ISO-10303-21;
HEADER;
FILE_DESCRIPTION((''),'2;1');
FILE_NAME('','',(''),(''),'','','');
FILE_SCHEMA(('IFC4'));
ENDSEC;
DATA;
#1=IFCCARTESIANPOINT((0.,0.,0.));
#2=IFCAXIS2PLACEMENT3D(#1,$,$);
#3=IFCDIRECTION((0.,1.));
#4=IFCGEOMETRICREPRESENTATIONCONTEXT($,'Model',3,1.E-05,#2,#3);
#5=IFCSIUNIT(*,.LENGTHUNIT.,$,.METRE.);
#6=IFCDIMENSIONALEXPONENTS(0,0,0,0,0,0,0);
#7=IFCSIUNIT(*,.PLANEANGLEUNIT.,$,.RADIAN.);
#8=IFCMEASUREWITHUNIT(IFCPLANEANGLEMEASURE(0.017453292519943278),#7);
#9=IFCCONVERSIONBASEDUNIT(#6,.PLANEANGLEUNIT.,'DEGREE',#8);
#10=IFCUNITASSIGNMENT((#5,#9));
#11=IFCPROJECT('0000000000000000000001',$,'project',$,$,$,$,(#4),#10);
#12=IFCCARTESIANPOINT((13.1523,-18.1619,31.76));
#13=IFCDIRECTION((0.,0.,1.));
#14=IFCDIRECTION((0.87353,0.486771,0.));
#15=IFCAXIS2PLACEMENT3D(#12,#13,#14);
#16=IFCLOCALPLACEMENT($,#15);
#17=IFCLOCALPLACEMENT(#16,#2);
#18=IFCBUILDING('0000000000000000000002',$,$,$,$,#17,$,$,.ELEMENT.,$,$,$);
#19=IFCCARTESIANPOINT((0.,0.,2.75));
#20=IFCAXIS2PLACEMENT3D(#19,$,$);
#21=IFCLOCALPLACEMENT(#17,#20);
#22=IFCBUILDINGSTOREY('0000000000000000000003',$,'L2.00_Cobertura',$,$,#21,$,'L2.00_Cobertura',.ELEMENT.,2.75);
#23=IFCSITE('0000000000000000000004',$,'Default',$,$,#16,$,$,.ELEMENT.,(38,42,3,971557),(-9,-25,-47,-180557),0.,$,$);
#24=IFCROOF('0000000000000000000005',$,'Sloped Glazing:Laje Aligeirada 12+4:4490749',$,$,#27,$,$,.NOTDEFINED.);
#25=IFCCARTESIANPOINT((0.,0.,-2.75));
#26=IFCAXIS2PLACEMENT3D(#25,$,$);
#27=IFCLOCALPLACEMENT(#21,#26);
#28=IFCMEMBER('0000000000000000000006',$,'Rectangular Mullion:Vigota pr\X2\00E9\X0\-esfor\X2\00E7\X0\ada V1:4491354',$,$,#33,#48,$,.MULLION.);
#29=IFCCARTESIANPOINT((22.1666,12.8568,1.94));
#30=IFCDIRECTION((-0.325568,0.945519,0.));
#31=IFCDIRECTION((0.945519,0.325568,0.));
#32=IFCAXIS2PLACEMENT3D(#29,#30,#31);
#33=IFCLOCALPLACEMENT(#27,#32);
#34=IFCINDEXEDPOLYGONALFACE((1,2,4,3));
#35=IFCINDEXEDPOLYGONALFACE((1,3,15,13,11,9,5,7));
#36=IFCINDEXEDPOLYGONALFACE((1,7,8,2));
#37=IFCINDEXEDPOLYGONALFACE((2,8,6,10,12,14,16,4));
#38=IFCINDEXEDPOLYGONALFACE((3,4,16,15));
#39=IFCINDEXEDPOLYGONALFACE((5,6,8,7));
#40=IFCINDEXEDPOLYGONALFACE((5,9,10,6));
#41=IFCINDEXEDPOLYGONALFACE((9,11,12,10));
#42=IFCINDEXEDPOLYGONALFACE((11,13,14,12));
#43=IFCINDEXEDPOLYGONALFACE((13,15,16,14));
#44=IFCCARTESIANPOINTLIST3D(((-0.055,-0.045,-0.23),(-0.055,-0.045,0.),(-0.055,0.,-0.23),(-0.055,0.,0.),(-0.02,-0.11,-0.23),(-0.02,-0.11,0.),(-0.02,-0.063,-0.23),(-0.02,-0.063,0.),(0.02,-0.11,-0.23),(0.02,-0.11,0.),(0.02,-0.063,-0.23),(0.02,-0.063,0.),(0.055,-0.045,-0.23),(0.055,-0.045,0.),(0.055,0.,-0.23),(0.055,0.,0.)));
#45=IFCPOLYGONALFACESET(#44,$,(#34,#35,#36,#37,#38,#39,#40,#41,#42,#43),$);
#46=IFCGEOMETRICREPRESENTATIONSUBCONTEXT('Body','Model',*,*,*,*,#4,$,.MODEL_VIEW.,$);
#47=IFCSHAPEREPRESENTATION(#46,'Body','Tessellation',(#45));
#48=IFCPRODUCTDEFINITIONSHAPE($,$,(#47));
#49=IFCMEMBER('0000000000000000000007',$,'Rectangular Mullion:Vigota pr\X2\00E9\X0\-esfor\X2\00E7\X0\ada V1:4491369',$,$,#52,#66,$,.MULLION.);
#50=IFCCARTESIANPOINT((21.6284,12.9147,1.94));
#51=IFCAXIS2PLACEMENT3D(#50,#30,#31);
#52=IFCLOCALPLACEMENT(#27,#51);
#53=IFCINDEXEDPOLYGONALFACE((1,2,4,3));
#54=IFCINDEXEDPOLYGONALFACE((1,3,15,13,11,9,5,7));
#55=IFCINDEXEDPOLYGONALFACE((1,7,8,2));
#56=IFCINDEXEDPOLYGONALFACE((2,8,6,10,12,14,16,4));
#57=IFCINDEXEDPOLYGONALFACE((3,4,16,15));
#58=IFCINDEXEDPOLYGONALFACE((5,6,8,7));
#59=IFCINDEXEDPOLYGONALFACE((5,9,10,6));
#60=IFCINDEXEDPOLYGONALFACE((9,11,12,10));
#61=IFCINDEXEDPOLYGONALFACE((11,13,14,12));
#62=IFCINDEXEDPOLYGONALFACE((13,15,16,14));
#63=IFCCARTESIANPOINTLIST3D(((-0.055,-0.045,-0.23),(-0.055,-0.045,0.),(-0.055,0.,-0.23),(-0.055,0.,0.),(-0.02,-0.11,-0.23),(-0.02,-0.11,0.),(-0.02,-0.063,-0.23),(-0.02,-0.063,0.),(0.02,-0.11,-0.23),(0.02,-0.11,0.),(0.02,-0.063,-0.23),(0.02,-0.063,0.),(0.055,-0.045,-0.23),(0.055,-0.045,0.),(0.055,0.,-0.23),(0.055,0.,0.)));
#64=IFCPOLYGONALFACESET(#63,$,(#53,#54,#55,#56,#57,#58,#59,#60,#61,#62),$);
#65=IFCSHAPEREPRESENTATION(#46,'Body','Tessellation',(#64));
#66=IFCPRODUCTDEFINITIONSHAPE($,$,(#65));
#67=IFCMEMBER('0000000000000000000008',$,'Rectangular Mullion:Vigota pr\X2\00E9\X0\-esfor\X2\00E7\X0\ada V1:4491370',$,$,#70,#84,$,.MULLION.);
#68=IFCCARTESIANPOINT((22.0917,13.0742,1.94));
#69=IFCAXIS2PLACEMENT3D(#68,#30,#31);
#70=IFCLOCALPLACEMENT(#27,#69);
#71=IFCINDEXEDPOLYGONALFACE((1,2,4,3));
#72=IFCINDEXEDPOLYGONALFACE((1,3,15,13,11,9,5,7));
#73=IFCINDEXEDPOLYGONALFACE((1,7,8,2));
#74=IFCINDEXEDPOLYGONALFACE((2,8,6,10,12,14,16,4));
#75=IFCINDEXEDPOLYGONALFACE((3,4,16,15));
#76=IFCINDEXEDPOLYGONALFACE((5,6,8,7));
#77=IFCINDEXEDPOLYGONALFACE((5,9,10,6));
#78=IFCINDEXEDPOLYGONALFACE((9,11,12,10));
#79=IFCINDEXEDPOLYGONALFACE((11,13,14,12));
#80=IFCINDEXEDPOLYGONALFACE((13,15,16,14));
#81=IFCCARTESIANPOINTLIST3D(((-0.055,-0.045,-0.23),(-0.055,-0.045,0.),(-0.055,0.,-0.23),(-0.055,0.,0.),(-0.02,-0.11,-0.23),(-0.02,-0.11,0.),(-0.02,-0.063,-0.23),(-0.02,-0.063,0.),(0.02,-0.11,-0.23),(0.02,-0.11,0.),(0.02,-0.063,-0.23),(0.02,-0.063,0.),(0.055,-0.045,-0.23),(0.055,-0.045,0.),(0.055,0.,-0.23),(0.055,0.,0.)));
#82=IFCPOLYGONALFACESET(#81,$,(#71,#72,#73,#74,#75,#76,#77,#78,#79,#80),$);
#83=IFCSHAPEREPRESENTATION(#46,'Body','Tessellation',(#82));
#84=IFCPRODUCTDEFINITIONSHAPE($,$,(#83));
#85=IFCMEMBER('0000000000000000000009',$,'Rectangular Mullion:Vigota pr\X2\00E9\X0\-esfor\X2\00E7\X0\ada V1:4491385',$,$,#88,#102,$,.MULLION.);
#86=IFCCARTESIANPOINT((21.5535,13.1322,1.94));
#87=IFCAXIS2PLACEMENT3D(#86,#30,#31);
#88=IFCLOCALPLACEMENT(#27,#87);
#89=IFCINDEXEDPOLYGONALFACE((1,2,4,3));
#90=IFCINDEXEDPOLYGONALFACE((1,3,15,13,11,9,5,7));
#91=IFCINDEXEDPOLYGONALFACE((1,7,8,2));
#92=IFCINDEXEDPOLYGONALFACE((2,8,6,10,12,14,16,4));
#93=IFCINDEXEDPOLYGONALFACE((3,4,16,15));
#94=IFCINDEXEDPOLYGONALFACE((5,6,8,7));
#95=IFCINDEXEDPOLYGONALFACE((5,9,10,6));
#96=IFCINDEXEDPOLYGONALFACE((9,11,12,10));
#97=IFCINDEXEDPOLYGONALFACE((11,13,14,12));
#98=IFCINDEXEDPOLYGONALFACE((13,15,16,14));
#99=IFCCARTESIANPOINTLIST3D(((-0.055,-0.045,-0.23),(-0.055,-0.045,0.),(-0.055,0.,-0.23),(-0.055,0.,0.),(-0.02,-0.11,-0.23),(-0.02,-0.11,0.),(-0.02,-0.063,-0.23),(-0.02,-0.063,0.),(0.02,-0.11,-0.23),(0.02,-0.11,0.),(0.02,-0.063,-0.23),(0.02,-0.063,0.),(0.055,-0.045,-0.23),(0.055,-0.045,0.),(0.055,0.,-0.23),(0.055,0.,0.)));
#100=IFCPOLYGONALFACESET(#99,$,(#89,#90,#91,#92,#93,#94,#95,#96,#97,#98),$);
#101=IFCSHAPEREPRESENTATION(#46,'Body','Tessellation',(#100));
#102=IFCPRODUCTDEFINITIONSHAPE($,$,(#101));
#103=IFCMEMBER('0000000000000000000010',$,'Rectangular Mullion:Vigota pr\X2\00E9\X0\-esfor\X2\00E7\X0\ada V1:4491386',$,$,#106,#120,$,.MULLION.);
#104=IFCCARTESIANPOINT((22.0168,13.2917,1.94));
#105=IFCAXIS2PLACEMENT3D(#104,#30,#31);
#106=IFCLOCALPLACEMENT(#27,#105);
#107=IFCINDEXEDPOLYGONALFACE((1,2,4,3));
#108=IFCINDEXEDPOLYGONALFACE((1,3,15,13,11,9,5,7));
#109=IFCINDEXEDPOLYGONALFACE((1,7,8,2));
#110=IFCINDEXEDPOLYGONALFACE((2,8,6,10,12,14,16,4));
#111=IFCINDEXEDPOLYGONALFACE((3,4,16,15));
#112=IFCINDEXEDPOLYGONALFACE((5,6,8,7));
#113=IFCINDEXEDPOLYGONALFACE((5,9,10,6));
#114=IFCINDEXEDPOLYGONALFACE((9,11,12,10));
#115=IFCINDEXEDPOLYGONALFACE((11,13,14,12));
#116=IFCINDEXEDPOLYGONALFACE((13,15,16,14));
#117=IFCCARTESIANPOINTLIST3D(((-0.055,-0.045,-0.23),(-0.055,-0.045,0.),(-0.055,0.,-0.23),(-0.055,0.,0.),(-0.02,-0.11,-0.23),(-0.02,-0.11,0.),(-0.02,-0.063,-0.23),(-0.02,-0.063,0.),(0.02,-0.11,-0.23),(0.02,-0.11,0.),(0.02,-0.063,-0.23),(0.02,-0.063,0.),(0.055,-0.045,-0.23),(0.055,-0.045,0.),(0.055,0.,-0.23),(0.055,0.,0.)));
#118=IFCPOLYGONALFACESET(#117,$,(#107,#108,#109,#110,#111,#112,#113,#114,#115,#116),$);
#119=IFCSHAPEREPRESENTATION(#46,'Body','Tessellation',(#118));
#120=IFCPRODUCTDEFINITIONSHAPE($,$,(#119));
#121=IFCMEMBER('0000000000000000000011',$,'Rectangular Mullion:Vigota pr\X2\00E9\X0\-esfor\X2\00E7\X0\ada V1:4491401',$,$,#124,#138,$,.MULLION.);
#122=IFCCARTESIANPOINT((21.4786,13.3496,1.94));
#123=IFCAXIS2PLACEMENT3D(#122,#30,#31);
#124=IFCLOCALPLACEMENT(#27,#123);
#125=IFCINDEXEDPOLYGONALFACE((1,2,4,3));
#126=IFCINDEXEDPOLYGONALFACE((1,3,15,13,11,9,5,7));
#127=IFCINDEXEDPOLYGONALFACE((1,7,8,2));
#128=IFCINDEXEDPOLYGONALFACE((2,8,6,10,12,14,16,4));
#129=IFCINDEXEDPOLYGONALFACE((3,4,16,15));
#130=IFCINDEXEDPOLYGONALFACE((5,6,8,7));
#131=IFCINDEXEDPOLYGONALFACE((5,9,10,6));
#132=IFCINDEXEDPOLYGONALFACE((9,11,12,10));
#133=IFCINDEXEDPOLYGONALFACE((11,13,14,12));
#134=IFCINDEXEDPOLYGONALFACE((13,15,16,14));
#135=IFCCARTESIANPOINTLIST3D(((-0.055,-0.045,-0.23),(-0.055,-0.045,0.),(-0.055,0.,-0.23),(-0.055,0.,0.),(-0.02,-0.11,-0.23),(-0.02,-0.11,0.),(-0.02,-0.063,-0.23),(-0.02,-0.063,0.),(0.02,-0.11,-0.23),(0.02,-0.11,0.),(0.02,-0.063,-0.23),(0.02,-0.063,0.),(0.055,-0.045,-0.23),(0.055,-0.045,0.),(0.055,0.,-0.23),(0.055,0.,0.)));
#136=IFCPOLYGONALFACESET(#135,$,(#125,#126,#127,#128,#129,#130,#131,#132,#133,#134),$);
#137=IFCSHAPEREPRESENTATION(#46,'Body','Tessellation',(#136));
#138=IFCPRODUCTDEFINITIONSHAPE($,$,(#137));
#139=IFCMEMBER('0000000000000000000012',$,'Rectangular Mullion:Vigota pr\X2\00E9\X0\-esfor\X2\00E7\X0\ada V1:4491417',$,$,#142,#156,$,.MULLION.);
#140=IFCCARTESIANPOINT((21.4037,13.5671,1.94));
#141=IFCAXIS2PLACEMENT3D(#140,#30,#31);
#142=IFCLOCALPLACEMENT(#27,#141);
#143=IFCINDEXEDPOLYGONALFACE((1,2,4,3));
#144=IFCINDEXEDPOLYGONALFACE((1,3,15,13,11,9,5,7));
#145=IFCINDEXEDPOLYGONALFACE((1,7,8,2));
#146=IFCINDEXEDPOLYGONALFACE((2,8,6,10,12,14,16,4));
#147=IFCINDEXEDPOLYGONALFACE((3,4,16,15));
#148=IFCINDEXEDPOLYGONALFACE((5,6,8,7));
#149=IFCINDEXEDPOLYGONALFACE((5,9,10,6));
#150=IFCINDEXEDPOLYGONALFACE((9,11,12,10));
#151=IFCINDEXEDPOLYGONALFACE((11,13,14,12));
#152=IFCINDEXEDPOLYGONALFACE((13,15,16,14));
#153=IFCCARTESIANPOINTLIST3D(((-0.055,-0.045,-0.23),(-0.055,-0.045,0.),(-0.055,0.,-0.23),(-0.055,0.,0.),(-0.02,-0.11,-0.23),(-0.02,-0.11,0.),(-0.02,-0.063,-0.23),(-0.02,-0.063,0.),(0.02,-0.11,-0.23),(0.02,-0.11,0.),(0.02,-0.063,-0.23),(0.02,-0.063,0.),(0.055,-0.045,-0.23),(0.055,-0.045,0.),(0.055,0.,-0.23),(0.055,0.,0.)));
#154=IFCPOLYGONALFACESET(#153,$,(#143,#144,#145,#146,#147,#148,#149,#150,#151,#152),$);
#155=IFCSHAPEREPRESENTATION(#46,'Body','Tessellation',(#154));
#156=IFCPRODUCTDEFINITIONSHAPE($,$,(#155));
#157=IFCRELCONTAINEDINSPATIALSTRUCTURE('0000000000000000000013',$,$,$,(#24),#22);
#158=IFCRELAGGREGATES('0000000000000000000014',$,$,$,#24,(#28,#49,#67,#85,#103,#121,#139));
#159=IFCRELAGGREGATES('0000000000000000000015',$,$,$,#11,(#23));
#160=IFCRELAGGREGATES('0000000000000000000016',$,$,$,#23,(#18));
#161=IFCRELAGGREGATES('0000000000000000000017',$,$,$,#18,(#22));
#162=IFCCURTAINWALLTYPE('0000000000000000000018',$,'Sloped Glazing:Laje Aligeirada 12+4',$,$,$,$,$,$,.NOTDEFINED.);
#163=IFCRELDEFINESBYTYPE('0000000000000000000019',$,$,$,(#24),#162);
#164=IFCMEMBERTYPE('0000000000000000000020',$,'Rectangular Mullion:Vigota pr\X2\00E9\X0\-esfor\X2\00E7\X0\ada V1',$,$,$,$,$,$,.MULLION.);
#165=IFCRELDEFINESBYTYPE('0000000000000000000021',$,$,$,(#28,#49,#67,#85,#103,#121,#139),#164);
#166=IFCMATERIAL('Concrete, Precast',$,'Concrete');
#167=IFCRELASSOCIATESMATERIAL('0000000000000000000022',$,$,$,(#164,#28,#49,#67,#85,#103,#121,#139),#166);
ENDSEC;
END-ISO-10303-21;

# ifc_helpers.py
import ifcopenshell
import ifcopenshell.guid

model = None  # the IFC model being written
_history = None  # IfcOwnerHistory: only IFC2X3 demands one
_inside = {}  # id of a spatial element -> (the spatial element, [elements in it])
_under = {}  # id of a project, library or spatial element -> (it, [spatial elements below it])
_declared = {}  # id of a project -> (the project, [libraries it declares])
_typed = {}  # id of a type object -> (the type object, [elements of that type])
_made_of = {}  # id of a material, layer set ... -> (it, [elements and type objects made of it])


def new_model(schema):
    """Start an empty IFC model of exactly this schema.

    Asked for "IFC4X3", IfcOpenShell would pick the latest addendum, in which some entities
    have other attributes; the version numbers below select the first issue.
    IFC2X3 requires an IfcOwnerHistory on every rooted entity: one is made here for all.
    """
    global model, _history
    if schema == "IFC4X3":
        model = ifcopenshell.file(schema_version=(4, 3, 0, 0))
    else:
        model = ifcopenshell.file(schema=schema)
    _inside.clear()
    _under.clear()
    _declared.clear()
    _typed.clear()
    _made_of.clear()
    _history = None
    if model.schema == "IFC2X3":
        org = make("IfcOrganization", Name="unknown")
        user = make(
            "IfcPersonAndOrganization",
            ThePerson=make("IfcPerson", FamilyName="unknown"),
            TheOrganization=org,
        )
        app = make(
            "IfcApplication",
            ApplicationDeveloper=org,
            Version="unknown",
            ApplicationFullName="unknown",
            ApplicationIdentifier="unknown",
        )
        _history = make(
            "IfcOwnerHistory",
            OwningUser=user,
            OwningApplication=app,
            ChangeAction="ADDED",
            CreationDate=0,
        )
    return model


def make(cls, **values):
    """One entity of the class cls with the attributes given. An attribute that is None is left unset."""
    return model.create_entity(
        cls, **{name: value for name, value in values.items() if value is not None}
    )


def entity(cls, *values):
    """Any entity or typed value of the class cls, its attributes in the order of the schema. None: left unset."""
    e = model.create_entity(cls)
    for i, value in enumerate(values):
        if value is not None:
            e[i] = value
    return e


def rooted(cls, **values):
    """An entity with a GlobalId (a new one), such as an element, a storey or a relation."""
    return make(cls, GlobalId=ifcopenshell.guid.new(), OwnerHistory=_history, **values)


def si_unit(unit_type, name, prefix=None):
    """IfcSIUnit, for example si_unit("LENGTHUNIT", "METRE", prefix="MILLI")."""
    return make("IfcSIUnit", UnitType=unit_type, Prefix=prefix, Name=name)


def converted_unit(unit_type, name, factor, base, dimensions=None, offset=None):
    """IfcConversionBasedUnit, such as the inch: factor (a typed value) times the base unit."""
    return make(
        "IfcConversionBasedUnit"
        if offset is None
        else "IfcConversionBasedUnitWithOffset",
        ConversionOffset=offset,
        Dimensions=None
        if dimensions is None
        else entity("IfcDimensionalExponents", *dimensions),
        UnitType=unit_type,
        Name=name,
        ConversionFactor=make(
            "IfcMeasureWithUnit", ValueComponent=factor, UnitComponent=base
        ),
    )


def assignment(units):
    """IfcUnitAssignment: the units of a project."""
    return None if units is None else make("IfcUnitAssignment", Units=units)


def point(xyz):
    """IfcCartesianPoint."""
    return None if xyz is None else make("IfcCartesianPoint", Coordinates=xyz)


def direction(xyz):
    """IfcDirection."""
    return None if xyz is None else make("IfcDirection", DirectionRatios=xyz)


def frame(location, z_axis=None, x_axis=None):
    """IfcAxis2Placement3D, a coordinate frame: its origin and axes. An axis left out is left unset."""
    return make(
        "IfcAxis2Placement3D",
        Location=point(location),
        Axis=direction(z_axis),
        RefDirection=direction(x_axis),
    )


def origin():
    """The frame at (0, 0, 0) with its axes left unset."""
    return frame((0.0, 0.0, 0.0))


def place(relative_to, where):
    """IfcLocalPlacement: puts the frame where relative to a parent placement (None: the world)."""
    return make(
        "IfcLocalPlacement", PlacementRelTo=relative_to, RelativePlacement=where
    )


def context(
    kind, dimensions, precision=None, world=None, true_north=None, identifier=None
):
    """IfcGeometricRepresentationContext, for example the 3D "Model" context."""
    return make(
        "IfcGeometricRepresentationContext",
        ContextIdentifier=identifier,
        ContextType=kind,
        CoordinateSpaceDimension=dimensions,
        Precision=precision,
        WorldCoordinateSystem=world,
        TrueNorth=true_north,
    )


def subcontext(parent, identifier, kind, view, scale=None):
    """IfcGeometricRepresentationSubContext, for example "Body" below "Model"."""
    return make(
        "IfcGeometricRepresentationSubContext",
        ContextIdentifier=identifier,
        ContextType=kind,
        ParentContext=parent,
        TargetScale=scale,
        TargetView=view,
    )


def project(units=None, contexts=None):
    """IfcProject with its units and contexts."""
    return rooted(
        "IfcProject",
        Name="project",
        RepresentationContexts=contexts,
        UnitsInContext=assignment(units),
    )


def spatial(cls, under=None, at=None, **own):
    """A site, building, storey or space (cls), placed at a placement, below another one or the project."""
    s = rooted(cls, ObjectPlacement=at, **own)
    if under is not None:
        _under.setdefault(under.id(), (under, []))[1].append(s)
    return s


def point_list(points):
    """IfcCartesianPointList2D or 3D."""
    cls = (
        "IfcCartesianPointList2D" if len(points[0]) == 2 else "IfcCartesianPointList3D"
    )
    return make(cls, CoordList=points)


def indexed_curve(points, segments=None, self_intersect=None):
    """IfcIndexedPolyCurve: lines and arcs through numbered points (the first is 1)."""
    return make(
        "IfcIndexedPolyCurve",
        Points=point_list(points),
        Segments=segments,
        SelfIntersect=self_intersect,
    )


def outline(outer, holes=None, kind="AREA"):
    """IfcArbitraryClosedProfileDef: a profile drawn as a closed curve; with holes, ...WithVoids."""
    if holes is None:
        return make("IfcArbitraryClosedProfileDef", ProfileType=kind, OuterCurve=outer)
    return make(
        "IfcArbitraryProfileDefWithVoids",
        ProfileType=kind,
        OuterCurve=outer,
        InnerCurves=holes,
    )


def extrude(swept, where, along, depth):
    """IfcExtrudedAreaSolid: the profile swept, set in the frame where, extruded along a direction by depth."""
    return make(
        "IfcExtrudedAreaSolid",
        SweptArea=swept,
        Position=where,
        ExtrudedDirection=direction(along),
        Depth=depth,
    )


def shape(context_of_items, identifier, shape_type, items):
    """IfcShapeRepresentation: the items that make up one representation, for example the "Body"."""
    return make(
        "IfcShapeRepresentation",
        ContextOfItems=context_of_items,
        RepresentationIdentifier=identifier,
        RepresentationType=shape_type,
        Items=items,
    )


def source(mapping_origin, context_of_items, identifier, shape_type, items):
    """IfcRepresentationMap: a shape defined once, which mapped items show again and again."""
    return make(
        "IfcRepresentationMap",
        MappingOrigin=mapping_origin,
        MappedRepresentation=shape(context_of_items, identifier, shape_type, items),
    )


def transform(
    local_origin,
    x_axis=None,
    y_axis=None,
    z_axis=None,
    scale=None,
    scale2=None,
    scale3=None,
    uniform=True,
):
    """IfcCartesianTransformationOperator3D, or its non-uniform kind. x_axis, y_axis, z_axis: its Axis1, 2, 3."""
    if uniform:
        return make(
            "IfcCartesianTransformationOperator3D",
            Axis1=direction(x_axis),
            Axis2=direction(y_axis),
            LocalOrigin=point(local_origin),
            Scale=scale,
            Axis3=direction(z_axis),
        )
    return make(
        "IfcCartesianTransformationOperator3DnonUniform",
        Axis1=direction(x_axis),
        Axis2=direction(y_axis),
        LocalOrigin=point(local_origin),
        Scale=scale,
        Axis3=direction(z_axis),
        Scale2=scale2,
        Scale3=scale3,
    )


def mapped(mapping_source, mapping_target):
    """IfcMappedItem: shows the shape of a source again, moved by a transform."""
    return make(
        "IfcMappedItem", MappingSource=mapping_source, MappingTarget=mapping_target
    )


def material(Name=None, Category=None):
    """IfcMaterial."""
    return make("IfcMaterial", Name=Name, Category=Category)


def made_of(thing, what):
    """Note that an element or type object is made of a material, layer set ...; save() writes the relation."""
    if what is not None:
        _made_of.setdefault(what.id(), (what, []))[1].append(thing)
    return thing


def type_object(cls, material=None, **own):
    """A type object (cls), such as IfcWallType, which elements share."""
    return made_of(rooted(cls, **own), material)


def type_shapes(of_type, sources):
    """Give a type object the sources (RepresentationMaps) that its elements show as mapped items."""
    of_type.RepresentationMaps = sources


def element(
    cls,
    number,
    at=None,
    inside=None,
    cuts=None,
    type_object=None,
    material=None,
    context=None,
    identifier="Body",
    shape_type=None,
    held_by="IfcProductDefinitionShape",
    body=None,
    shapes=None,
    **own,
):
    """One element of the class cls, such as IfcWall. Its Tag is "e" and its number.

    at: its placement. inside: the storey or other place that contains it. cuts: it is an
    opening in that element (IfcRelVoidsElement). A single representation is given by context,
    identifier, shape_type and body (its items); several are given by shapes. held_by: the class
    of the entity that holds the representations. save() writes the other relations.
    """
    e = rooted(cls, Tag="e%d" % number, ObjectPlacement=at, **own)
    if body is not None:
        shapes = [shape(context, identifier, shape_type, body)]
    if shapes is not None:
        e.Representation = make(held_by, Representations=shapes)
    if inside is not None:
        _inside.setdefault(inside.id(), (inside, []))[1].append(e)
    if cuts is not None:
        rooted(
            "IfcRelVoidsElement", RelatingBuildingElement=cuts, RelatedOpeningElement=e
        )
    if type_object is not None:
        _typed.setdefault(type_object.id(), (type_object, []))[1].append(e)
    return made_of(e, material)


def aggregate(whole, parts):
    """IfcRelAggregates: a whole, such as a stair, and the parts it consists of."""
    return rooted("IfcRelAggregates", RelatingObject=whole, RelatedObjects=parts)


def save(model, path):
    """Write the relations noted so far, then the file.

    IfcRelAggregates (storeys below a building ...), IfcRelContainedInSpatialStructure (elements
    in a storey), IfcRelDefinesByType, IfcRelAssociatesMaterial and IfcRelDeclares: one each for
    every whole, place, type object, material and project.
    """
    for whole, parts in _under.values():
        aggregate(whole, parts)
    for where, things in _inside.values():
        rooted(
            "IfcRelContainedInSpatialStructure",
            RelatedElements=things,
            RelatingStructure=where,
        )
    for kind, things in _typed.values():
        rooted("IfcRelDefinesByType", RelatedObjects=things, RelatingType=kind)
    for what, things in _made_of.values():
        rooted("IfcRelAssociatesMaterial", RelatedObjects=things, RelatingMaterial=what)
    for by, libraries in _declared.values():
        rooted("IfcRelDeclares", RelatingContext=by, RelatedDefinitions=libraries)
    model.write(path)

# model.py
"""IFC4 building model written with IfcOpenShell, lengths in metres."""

from ifc_helpers import new_model, entity, si_unit, converted_unit, direction, frame, origin, place, context, subcontext, project, spatial, indexed_curve, outline, extrude, source, transform, mapped, material, type_object, type_shapes, element, aggregate, save


model = new_model("IFC4")

# Units and contexts
model_context = context("Model", 3, precision=1e-05, world=origin(), true_north=direction((0.0, 1.0)))
body_context = subcontext(model_context, "Body", "Model", "MODEL_VIEW")
ifc_project = project(units=[si_unit("LENGTHUNIT", "METRE"), converted_unit("PLANEANGLEUNIT", "DEGREE", entity("IfcPlaneAngleMeasure", 0.017453292519943278), si_unit("PLANEANGLEUNIT", "RADIAN"), dimensions=[0, 0, 0, 0, 0, 0, 0])], contexts=[model_context])

# Site, building, storey
site_placement = place(None, frame((13.1523, -18.1619, 31.76), z_axis=(0.0, 0.0, 1.0), x_axis=(0.87353, 0.486771, 0.0)))
site = spatial("IfcSite", under=ifc_project, at=site_placement, Name="Default", CompositionType="ELEMENT", RefLatitude=(38, 42, 3, 971557), RefLongitude=(-9, -25, -47, -180557), RefElevation=0.0)
building_placement = place(site_placement, origin())
building = spatial("IfcBuilding", under=site, at=building_placement, CompositionType="ELEMENT")
storey_placement = place(building_placement, frame((0.0, 0.0, 2.75)))
storey = spatial("IfcBuildingStorey", under=building, at=storey_placement, Name="L2.00_Cobertura", LongName="L2.00_Cobertura", CompositionType="ELEMENT", Elevation=2.75)

# Roof, members
curtain_wall_type = type_object("IfcCurtainWallType", Name="Sloped Glazing:Laje Aligeirada 12+4", PredefinedType="NOTDEFINED")
roof_placement = place(storey_placement, frame((0.0, 0.0, -2.75)))
roof = element("IfcRoof", 1, at=roof_placement, inside=storey, type_object=curtain_wall_type, Name="Sloped Glazing:Laje Aligeirada 12+4:4490749", PredefinedType="NOTDEFINED")
ifc_material_1 = material(Name="Concrete, Precast", Category="Concrete")
member_type = type_object("IfcMemberType", Name="Rectangular Mullion:Vigota pré-esforçada V1", PredefinedType="MULLION", material=ifc_material_1)
shared_shape_1 = source(origin(), body_context, "Body", "SweptSolid", [
    extrude(outline(indexed_curve([(-0.055, -0.0545), (0.055, -0.0545), (0.055, -0.0095), (0.02, 0.0085), (0.02, 0.0555), (-0.02, 0.0555), (-0.02, 0.0085), (-0.055, -0.0095), (-0.055, -0.0545)], self_intersect=False)), frame((0.0, -0.0545, -0.23), z_axis=(0.0, 0.0, 1.0), x_axis=(-1.0, 0.0, 0.0)), (0.0, 0.0, 1.0), 0.23),
])
type_shapes(member_type, [shared_shape_1])
member_1_placement = place(roof_placement, frame((22.1666, 12.8568, 1.94), z_axis=(-0.325568, 0.945519, 0.0), x_axis=(0.945519, 0.325568, 0.0)))
member_1 = element("IfcMember", 2, at=member_1_placement, type_object=member_type, material=ifc_material_1, Name="Rectangular Mullion:Vigota pré-esforçada V1:4491354", PredefinedType="MULLION", context=body_context, shape_type="MappedRepresentation", body=[
    mapped(shared_shape_1, transform((0.0, 0.0, 0.0), scale=1.0)),
])
member_2_placement = place(roof_placement, frame((21.6284, 12.9147, 1.94), z_axis=(-0.325568, 0.945519, 0.0), x_axis=(0.945519, 0.325568, 0.0)))
member_2 = element("IfcMember", 3, at=member_2_placement, type_object=member_type, material=ifc_material_1, Name="Rectangular Mullion:Vigota pré-esforçada V1:4491369", PredefinedType="MULLION", context=body_context, shape_type="MappedRepresentation", body=[
    mapped(shared_shape_1, transform((0.0, 0.0, 0.0), scale=1.0)),
])
member_3_placement = place(roof_placement, frame((22.0917, 13.0742, 1.94), z_axis=(-0.325568, 0.945519, 0.0), x_axis=(0.945519, 0.325568, 0.0)))
member_3 = element("IfcMember", 4, at=member_3_placement, type_object=member_type, material=ifc_material_1, Name="Rectangular Mullion:Vigota pré-esforçada V1:4491370", PredefinedType="MULLION", context=body_context, shape_type="MappedRepresentation", body=[
    mapped(shared_shape_1, transform((0.0, 0.0, 0.0), scale=1.0)),
])
member_4_placement = place(roof_placement, frame((21.5535, 13.1322, 1.94), z_axis=(-0.325568, 0.945519, 0.0), x_axis=(0.945519, 0.325568, 0.0)))
member_4 = element("IfcMember", 5, at=member_4_placement, type_object=member_type, material=ifc_material_1, Name="Rectangular Mullion:Vigota pré-esforçada V1:4491385", PredefinedType="MULLION", context=body_context, shape_type="MappedRepresentation", body=[
    mapped(shared_shape_1, transform((0.0, 0.0, 0.0), scale=1.0)),
])
member_5_placement = place(roof_placement, frame((22.0168, 13.2917, 1.94), z_axis=(-0.325568, 0.945519, 0.0), x_axis=(0.945519, 0.325568, 0.0)))
member_5 = element("IfcMember", 6, at=member_5_placement, type_object=member_type, material=ifc_material_1, Name="Rectangular Mullion:Vigota pré-esforçada V1:4491386", PredefinedType="MULLION", context=body_context, shape_type="MappedRepresentation", body=[
    mapped(shared_shape_1, transform((0.0, 0.0, 0.0), scale=1.0)),
])
member_6_placement = place(roof_placement, frame((21.4786, 13.3496, 1.94), z_axis=(-0.325568, 0.945519, 0.0), x_axis=(0.945519, 0.325568, 0.0)))
member_6 = element("IfcMember", 7, at=member_6_placement, type_object=member_type, material=ifc_material_1, Name="Rectangular Mullion:Vigota pré-esforçada V1:4491401", PredefinedType="MULLION", context=body_context, shape_type="MappedRepresentation", body=[
    mapped(shared_shape_1, transform((0.0, 0.0, 0.0), scale=1.0)),
])
member_7_placement = place(roof_placement, frame((21.4037, 13.5671, 1.94), z_axis=(-0.325568, 0.945519, 0.0), x_axis=(0.945519, 0.325568, 0.0)))
member_7 = element("IfcMember", 8, at=member_7_placement, type_object=member_type, material=ifc_material_1, Name="Rectangular Mullion:Vigota pré-esforçada V1:4491417", PredefinedType="MULLION", context=body_context, shape_type="MappedRepresentation", body=[
    mapped(shared_shape_1, transform((0.0, 0.0, 0.0), scale=1.0)),
])
aggregate(roof, [member_1, member_2, member_3, member_4, member_5, member_6, member_7])

save(model, "model.ifc")
